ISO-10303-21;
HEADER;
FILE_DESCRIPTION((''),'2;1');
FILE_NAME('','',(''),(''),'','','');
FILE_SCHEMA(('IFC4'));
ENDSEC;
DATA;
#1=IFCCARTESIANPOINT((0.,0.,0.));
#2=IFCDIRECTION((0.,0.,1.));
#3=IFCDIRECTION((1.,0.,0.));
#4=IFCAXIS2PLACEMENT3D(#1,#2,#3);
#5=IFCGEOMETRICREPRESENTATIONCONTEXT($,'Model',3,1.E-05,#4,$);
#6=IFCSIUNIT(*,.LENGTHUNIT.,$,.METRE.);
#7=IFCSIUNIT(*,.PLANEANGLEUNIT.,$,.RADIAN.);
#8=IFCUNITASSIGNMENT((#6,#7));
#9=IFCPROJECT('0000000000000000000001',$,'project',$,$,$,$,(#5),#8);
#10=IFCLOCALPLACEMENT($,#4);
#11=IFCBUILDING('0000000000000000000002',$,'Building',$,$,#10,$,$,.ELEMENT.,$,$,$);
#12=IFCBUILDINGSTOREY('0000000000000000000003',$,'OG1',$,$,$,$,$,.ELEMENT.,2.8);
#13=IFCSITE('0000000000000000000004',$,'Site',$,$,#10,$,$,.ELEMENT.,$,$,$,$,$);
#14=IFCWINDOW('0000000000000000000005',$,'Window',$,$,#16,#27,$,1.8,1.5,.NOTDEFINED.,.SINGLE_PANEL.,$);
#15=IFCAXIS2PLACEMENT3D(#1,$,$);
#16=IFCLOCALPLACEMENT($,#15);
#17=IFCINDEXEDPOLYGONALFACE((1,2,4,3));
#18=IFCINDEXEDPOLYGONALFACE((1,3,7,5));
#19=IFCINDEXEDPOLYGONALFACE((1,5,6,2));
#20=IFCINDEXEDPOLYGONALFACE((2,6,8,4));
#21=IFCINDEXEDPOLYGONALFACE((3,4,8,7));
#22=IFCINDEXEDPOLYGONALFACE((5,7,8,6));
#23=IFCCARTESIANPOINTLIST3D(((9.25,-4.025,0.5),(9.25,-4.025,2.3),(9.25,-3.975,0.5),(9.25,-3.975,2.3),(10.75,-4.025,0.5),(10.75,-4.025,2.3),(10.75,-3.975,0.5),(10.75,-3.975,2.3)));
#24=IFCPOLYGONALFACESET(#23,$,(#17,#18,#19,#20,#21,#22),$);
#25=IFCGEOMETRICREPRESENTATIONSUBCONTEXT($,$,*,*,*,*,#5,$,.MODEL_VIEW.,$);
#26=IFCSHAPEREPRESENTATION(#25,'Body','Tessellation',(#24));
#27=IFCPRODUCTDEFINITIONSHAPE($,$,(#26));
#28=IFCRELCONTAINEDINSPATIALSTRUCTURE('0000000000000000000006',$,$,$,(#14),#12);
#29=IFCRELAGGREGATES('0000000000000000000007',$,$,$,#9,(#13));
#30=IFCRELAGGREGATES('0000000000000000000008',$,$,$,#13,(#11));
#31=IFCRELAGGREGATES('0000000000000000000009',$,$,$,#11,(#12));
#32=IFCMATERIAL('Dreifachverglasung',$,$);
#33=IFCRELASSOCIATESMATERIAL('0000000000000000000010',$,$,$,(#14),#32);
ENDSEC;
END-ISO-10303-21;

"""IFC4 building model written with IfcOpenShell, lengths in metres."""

from ifc_helpers import new_model, si_unit, frame, origin, origin_with_axes, origin_2d, place, context, subcontext, project, spatial, rectangle, extrude, material, element, save


model = new_model("IFC4")

# Units and contexts
model_context = context("Model", 3, precision=1e-05, world=origin_with_axes())
sub_context = subcontext(model_context, None, None, "MODEL_VIEW")
ifc_project = project(units=[si_unit("LENGTHUNIT", "METRE"), si_unit("PLANEANGLEUNIT", "RADIAN")], contexts=[model_context])

# Site, building, storey
placement_1 = place(None, origin_with_axes())
site = spatial("IfcSite", under=ifc_project, at=placement_1, Name="Site", CompositionType="ELEMENT")
building = spatial("IfcBuilding", under=site, at=placement_1, Name="Building", CompositionType="ELEMENT")
storey = spatial("IfcBuildingStorey", under=building, Name="OG1", CompositionType="ELEMENT", Elevation=2.8)

# Window
ifc_material = material(Name="Dreifachverglasung")
placement_2 = place(None, origin_with_axes())
window_placement = place(placement_2, frame((10.0, -4.0, 0.5)))
element("IfcWindow", 1, at=window_placement, inside=storey, material=ifc_material, Name="Window", OverallHeight=1.8, OverallWidth=1.5, PartitioningType="SINGLE_PANEL", PredefinedType="NOTDEFINED", context=sub_context, shape_type="SweptSolid", body=[
    extrude(rectangle(XDim=1.5, YDim=0.05, at=origin_2d()), origin(), (0.0, 0.0, 1.0), 1.8),
])

save(model, "model.ifc")
